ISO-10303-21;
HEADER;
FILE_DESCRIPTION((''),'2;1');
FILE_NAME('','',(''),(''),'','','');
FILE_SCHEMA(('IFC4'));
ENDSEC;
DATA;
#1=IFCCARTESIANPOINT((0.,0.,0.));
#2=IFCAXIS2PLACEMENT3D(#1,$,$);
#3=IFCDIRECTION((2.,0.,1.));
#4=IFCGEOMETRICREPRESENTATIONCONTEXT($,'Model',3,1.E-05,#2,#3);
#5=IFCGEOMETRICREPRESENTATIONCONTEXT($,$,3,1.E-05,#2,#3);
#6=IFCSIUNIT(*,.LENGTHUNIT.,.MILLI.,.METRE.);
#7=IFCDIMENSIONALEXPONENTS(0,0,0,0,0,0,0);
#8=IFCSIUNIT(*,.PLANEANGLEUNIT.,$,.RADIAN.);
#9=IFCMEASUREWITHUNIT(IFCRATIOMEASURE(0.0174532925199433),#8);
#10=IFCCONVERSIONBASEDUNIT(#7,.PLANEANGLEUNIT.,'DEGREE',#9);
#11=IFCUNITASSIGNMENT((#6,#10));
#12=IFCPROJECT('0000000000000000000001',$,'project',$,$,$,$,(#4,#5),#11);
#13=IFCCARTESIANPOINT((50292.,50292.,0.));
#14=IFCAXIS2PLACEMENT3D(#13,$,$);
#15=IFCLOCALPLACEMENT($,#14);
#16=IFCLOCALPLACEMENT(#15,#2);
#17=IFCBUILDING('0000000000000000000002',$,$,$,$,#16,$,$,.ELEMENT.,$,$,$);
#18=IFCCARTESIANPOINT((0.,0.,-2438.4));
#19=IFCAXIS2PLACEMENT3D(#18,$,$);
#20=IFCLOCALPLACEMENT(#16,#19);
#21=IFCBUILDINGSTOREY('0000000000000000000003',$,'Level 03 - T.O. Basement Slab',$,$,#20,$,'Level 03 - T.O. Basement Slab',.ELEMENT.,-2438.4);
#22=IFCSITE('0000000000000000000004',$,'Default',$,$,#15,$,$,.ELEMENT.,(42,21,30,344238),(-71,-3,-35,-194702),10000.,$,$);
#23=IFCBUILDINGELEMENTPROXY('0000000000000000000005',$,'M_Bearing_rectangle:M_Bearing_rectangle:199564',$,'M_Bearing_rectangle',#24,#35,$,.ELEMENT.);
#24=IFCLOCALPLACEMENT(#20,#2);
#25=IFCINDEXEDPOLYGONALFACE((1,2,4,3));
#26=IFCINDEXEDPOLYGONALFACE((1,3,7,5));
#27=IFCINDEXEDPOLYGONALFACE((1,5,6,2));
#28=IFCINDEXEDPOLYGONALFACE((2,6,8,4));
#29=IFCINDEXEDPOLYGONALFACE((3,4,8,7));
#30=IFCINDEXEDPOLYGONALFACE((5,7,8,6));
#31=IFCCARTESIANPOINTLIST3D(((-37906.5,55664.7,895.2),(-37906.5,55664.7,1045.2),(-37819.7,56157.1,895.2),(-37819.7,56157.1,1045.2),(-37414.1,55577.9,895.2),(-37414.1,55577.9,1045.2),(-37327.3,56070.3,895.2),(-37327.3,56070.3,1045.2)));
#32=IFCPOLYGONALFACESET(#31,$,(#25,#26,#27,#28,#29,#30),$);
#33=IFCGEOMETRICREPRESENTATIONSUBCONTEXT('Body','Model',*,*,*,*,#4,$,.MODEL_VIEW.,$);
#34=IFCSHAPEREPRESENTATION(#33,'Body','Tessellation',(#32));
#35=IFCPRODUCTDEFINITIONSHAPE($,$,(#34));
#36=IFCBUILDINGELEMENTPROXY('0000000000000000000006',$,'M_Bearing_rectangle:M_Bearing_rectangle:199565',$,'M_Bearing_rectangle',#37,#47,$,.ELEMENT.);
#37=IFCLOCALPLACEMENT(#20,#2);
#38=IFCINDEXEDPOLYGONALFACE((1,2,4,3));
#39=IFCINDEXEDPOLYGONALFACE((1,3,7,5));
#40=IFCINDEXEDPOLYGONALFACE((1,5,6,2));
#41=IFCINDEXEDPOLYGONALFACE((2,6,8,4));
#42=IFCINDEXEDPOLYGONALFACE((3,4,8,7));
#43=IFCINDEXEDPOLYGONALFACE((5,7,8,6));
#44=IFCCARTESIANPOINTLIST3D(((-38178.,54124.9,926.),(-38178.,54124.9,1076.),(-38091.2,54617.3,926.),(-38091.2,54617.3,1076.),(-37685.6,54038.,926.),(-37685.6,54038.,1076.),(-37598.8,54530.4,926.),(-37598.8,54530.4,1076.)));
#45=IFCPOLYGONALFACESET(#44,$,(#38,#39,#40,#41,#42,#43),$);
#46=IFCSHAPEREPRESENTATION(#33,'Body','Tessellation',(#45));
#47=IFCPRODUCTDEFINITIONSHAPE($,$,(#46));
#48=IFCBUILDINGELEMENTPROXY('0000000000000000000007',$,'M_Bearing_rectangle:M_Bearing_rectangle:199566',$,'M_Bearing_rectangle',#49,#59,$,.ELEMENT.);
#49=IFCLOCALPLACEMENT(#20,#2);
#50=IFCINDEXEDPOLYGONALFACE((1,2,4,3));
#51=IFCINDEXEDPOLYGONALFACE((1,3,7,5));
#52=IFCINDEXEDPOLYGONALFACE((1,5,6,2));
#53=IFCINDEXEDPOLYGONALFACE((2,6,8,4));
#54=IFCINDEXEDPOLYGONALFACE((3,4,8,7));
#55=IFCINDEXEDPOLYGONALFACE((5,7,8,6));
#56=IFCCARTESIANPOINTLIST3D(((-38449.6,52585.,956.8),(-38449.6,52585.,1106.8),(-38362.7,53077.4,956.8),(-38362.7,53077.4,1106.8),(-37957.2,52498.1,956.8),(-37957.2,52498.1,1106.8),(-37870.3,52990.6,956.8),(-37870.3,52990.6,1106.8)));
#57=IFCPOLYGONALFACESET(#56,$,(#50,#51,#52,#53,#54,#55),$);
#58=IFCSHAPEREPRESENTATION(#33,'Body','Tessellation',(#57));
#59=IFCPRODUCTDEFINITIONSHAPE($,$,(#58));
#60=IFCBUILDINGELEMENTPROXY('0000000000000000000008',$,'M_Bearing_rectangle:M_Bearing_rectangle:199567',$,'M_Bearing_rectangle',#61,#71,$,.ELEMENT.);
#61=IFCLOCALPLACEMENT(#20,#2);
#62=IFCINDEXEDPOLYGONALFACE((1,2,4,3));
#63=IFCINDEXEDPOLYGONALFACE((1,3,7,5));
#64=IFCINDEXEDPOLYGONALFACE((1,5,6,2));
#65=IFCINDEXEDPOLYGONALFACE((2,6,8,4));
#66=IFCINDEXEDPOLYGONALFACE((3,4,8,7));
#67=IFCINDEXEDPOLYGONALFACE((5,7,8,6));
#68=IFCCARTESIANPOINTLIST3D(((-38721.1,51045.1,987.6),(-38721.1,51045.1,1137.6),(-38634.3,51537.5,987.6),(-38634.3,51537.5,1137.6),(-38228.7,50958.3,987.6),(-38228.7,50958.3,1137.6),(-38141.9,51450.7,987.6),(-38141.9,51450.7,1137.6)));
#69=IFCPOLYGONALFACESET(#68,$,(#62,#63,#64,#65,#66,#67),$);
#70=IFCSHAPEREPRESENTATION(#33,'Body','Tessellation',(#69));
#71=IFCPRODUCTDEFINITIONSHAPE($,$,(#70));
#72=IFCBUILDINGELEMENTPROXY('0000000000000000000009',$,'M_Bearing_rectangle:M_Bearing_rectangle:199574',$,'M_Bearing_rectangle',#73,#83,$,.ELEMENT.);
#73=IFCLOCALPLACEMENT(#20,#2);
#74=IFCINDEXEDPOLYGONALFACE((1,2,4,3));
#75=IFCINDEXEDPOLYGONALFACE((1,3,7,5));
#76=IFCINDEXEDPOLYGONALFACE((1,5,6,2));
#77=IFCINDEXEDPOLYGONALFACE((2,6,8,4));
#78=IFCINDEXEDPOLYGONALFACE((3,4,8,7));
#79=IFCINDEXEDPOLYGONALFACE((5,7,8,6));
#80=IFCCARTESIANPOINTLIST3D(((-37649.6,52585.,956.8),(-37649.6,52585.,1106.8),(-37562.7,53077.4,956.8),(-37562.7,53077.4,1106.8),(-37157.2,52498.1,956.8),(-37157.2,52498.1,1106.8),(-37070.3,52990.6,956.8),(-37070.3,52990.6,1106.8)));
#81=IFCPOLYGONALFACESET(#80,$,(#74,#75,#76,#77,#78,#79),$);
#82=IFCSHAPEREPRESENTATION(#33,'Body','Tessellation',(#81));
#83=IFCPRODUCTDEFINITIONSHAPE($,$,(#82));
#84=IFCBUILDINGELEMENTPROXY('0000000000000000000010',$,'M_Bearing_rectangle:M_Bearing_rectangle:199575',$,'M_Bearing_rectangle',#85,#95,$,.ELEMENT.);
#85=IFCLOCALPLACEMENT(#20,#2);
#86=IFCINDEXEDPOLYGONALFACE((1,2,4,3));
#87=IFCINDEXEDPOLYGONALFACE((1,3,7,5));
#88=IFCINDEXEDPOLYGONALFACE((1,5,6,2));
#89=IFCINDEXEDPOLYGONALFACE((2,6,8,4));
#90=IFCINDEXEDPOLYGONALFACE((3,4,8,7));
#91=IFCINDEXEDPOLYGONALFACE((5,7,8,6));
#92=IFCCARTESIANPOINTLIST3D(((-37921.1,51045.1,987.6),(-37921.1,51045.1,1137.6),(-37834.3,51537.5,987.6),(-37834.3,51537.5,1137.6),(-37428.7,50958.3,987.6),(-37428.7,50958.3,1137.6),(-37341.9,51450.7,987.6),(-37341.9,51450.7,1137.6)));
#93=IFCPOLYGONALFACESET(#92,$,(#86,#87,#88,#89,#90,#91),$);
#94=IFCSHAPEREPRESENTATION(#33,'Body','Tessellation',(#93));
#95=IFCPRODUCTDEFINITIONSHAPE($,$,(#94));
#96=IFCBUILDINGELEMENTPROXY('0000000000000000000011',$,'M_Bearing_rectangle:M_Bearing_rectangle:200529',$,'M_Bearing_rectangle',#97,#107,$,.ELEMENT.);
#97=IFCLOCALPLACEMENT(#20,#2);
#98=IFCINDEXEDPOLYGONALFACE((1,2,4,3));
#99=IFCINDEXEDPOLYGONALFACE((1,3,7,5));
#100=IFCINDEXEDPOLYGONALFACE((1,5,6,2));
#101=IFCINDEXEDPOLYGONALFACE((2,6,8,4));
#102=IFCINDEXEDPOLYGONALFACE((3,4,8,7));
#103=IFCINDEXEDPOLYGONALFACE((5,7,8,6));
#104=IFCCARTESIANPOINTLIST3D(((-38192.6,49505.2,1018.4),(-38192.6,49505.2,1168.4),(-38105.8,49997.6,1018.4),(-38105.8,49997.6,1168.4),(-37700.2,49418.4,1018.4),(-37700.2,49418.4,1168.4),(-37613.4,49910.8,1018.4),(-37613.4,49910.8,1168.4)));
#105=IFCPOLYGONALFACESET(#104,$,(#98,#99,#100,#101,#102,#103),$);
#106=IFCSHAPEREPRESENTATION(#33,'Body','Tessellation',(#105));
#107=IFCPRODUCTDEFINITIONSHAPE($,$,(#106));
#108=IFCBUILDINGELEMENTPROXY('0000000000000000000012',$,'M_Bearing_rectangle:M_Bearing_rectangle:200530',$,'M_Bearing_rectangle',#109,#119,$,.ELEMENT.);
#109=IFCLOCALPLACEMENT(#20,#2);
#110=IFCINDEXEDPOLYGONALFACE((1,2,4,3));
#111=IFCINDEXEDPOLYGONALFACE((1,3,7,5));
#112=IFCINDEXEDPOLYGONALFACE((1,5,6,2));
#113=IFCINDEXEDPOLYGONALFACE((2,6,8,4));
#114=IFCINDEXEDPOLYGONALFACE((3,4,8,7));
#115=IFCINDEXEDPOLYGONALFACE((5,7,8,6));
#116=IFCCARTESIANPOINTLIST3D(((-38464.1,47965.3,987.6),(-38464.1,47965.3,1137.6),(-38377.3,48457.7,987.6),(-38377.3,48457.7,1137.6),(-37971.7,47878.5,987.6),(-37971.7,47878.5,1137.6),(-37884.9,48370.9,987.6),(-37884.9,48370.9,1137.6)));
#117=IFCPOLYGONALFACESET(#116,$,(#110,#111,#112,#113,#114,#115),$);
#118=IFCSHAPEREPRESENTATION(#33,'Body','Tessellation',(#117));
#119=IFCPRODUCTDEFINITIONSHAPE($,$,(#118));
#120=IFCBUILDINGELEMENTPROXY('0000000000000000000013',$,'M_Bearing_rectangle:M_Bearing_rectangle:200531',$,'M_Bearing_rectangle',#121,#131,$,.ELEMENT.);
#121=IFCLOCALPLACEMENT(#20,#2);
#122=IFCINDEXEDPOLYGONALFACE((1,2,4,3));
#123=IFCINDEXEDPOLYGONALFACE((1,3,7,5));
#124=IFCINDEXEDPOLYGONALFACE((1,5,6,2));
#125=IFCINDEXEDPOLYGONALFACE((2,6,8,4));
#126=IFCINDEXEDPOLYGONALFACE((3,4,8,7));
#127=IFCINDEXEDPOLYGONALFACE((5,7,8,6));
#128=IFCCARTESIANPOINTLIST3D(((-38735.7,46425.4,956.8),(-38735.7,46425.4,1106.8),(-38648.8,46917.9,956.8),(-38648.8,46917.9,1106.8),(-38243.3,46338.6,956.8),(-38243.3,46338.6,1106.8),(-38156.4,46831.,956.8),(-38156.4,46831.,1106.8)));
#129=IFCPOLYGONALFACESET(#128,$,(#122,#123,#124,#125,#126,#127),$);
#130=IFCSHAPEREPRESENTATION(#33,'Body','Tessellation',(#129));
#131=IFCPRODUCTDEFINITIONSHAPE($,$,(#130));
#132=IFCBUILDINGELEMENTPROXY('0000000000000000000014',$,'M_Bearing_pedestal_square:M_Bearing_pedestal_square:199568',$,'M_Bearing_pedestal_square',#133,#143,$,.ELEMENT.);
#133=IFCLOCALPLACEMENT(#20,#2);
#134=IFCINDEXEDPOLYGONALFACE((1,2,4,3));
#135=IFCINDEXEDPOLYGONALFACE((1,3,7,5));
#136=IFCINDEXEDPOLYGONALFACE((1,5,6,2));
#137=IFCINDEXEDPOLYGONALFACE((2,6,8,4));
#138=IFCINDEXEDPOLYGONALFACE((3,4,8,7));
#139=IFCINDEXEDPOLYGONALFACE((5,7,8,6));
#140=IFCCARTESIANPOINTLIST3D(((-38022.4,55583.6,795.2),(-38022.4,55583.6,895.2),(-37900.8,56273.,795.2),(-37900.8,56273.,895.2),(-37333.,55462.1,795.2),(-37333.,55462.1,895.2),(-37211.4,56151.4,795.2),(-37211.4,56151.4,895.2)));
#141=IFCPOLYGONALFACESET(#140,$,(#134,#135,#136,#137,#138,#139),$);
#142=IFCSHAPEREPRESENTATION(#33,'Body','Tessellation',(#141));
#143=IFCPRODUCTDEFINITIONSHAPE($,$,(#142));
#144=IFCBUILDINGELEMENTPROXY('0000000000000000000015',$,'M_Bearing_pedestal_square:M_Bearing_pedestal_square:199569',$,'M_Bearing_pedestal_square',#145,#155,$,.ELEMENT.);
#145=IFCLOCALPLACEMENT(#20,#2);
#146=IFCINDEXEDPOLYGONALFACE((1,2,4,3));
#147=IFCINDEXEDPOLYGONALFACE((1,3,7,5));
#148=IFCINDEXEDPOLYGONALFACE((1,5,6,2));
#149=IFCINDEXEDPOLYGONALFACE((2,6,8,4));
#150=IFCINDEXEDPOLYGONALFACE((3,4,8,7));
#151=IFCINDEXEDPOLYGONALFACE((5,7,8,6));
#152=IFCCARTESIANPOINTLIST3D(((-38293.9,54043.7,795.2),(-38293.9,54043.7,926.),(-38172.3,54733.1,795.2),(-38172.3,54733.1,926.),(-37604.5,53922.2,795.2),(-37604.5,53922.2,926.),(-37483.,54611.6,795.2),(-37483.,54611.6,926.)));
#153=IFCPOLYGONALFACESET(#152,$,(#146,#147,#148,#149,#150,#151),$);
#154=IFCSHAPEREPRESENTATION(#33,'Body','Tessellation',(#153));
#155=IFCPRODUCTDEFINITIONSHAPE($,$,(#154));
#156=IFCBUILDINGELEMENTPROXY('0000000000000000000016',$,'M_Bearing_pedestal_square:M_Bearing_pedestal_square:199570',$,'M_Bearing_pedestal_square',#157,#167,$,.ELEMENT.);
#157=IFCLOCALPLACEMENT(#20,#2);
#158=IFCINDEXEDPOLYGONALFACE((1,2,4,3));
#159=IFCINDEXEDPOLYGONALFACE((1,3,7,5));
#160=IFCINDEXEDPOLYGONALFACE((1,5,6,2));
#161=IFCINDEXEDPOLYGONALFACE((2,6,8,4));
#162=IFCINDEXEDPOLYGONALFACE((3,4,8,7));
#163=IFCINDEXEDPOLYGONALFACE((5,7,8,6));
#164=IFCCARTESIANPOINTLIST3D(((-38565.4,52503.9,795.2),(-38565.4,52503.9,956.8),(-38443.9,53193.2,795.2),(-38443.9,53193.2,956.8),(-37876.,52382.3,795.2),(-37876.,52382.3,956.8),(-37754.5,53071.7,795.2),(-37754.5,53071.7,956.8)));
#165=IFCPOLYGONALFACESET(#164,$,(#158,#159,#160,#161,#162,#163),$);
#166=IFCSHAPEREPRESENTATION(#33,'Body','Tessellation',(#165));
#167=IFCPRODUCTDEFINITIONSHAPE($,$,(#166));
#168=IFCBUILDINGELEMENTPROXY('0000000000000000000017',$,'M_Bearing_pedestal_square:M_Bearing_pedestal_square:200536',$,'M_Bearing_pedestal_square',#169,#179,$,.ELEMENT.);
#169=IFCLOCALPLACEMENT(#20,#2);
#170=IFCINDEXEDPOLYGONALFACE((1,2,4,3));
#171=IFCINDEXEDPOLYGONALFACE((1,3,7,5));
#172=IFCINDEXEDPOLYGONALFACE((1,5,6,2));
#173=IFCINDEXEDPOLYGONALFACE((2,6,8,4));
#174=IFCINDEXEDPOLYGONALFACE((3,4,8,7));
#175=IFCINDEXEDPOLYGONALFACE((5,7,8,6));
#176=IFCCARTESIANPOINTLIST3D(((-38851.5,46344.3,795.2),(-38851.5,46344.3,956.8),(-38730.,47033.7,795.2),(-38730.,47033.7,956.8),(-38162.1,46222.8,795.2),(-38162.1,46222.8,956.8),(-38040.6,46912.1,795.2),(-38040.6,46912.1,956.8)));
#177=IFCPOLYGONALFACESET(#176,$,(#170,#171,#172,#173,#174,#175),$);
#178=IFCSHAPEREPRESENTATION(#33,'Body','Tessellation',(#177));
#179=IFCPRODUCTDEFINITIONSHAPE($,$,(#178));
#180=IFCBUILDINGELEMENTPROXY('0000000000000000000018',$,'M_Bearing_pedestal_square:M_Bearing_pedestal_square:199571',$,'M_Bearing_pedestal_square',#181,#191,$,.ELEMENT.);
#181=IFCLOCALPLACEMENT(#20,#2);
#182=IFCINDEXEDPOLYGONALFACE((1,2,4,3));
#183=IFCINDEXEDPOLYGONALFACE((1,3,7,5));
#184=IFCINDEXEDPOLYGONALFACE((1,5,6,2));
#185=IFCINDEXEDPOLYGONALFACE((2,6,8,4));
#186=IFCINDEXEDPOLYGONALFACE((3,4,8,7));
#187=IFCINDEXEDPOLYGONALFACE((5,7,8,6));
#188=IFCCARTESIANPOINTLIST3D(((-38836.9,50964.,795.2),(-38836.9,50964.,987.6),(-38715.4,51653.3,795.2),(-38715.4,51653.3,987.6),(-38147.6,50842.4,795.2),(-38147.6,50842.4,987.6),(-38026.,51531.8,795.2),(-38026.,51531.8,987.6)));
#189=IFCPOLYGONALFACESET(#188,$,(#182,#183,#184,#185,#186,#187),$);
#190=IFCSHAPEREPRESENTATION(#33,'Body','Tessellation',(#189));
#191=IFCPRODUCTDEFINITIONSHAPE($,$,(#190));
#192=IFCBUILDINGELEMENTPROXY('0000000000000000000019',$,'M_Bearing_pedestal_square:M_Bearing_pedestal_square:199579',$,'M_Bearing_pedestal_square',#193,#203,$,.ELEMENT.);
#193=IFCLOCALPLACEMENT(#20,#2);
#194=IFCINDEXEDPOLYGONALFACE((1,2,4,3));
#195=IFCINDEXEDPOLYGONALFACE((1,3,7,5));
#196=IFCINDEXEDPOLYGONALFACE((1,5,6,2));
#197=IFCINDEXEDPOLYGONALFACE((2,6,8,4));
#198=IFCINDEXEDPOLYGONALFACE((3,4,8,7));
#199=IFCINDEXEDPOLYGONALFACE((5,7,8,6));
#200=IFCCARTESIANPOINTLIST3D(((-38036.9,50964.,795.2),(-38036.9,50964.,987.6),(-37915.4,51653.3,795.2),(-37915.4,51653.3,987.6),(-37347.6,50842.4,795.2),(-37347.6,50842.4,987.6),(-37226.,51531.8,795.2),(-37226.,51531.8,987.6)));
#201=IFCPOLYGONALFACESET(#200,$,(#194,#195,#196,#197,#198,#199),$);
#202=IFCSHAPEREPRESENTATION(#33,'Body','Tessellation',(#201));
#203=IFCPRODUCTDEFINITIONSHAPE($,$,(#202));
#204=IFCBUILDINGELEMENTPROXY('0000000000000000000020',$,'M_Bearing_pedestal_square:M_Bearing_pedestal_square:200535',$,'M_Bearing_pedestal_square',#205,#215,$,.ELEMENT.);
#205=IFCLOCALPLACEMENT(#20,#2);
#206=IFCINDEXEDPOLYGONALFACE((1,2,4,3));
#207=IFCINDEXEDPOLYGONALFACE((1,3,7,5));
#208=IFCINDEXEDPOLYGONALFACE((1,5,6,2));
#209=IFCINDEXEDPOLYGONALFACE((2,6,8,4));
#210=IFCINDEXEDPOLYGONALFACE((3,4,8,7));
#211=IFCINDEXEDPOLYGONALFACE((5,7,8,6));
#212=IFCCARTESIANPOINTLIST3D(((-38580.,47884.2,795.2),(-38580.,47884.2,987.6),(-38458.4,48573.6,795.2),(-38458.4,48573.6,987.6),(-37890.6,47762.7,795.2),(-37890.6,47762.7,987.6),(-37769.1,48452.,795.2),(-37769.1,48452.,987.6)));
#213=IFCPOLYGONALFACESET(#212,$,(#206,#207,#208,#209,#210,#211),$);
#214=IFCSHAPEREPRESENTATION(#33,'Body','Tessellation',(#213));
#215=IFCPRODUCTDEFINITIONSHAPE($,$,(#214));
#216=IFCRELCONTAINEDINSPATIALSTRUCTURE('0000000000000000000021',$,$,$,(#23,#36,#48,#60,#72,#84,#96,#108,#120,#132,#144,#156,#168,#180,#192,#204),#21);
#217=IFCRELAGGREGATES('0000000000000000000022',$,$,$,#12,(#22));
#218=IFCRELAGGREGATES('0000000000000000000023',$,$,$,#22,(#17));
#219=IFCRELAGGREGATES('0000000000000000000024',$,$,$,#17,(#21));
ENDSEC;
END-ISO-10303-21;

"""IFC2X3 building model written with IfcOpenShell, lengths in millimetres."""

from ifc_helpers import new_model, entity, si_unit, converted_unit, direction, frame, origin, origin_2d_with_axis, place, context, subcontext, project, spatial, rectangle, extrude, source, transform, mapped, element, save


model = new_model("IFC2X3")

# Units and contexts
model_context = context("Model", 3, precision=1e-05, world=origin(), true_north=direction((2.0, 0.0, 1.0)))
context_of_model = context(None, 3, precision=1e-05, world=origin(), true_north=direction((2.0, 0.0, 1.0)))
body_context = subcontext(model_context, "Body", "Model", "MODEL_VIEW")
ifc_project = project(units=[si_unit("LENGTHUNIT", "METRE", prefix="MILLI"), converted_unit("PLANEANGLEUNIT", "DEGREE", entity("IfcRatioMeasure", 0.0174532925199433), si_unit("PLANEANGLEUNIT", "RADIAN"), dimensions=[0, 0, 0, 0, 0, 0, 0])], contexts=[model_context, context_of_model])

# Site, building, storey
site_placement = place(None, frame((50292.0, 50292.0, 0.0)))
site = spatial("IfcSite", under=ifc_project, at=site_placement, Name="Default", CompositionType="ELEMENT", RefLatitude=(42, 21, 30, 344238), RefLongitude=(-71, -3, -35, -194702), RefElevation=10000.0)
building_placement = place(site_placement, origin())
building = spatial("IfcBuilding", under=site, at=building_placement, CompositionType="ELEMENT")
storey_placement = place(building_placement, frame((0.0, 0.0, -2438.4)))
storey = spatial("IfcBuildingStorey", under=building, at=storey_placement, Name="Level 03 - T.O. Basement Slab", LongName="Level 03 - T.O. Basement Slab", CompositionType="ELEMENT", Elevation=-2438.4)

# Building element proxies
shared_shape_1 = source(origin(), body_context, "Body", "SweptSolid", [
    extrude(rectangle(XDim=500.0, YDim=500.0, at=origin_2d_with_axis()), frame((0.0, 0.0, -150.0), z_axis=(0.0, 0.0, 1.0), x_axis=(-1.0, 0.0, 0.0)), (0.0, 0.0, 1.0), 150.0),
])
for number, where, z_axis, x_axis, name in (
    (1, (-37616.9, 55867.5, 1045.2), (0.0, 0.0, 1.0), (0.173648, 0.984808, 0.0), "M_Bearing_rectangle:M_Bearing_rectangle:199564"),
    (2, (-37888.4, 54327.6, 1076.0), (0.0, 0.0, 1.0), (0.173648, 0.984808, 0.0), "M_Bearing_rectangle:M_Bearing_rectangle:199565"),
    (3, (-38160.0, 52787.8, 1106.8), (0.0, 0.0, 1.0), (0.173648, 0.984808, 0.0), "M_Bearing_rectangle:M_Bearing_rectangle:199566"),
    (4, (-38431.5, 51247.9, 1137.6), (0.0, 0.0, 1.0), (0.173648, 0.984808, 0.0), "M_Bearing_rectangle:M_Bearing_rectangle:199567"),
    (5, (-37360.0, 52787.8, 1106.8), (0.0, 0.0, 1.0), (0.173648, 0.984808, 0.0), "M_Bearing_rectangle:M_Bearing_rectangle:199574"),
    (6, (-37631.5, 51247.9, 1137.6), (0.0, 0.0, 1.0), (0.173648, 0.984808, 0.0), "M_Bearing_rectangle:M_Bearing_rectangle:199575"),
    (7, (-37903.0, 49708.0, 1168.4), (0.0, 0.0, 1.0), (0.173648, 0.984808, 0.0), "M_Bearing_rectangle:M_Bearing_rectangle:200529"),
    (8, (-38174.5, 48168.1, 1137.6), (0.0, 0.0, 1.0), (0.173648, 0.984808, 0.0), "M_Bearing_rectangle:M_Bearing_rectangle:200530"),
    (9, (-38446.0, 46628.2, 1106.8), (0.0, 0.0, 1.0), (0.173648, 0.984808, 0.0), "M_Bearing_rectangle:M_Bearing_rectangle:200531"),
):
    element("IfcBuildingElementProxy", number, at=place(storey_placement, frame(where, z_axis=z_axis, x_axis=x_axis)), inside=storey, Name=name, ObjectType="M_Bearing_rectangle", CompositionType="ELEMENT", context=body_context, shape_type="MappedRepresentation", body=[
        mapped(shared_shape_1, transform((0.0, 0.0, 0.0), scale=1.0)),
    ])
shared_shape_2 = source(origin(), body_context, "Body", "SweptSolid", [
    extrude(rectangle(XDim=700.0, YDim=700.0, at=origin_2d_with_axis()), frame((0.0, 0.0, -100.0)), (0.0, 0.0, 1.0), 100.0),
])
proxy_1_placement = place(storey_placement, frame((-37616.9, 55867.5, 895.2), z_axis=(0.0, 0.0, 1.0), x_axis=(0.173648, 0.984808, 0.0)))
element("IfcBuildingElementProxy", 10, at=proxy_1_placement, inside=storey, Name="M_Bearing_pedestal_square:M_Bearing_pedestal_square:199568", ObjectType="M_Bearing_pedestal_square", CompositionType="ELEMENT", context=body_context, shape_type="MappedRepresentation", body=[
    mapped(shared_shape_2, transform((0.0, 0.0, 0.0), scale=1.0)),
])
shared_shape_3 = source(origin(), body_context, "Body", "SweptSolid", [
    extrude(rectangle(XDim=700.0, YDim=700.0, at=origin_2d_with_axis()), frame((0.0, 0.0, -130.8)), (0.0, 0.0, 1.0), 130.8),
])
proxy_2_placement = place(storey_placement, frame((-37888.4, 54327.6, 926.0), z_axis=(0.0, 0.0, 1.0), x_axis=(0.173648, 0.984808, 0.0)))
element("IfcBuildingElementProxy", 11, at=proxy_2_placement, inside=storey, Name="M_Bearing_pedestal_square:M_Bearing_pedestal_square:199569", ObjectType="M_Bearing_pedestal_square", CompositionType="ELEMENT", context=body_context, shape_type="MappedRepresentation", body=[
    mapped(shared_shape_3, transform((0.0, 0.0, 0.0), scale=1.0)),
])
shared_shape_4 = source(origin(), body_context, "Body", "SweptSolid", [
    extrude(rectangle(XDim=700.0, YDim=700.0, at=origin_2d_with_axis()), frame((0.0, 0.0, -161.6)), (0.0, 0.0, 1.0), 161.6),
])
for number, where, z_axis, x_axis, name in (
    (12, (-38160.0, 52787.8, 956.8), (0.0, 0.0, 1.0), (0.173648, 0.984808, 0.0), "M_Bearing_pedestal_square:M_Bearing_pedestal_square:199570"),
    (13, (-38446.0, 46628.2, 956.8), (0.0, 0.0, 1.0), (0.173648, 0.984808, 0.0), "M_Bearing_pedestal_square:M_Bearing_pedestal_square:200536"),
):
    element("IfcBuildingElementProxy", number, at=place(storey_placement, frame(where, z_axis=z_axis, x_axis=x_axis)), inside=storey, Name=name, ObjectType="M_Bearing_pedestal_square", CompositionType="ELEMENT", context=body_context, shape_type="MappedRepresentation", body=[
        mapped(shared_shape_4, transform((0.0, 0.0, 0.0), scale=1.0)),
    ])
shared_shape_5 = source(origin(), body_context, "Body", "SweptSolid", [
    extrude(rectangle(XDim=700.0, YDim=700.0, at=origin_2d_with_axis()), frame((0.0, 0.0, -192.4)), (0.0, 0.0, 1.0), 192.4),
])
for number, where, z_axis, x_axis, name in (
    (14, (-38431.5, 51247.9, 987.6), (0.0, 0.0, 1.0), (0.173648, 0.984808, 0.0), "M_Bearing_pedestal_square:M_Bearing_pedestal_square:199571"),
    (15, (-37631.5, 51247.9, 987.6), (0.0, 0.0, 1.0), (0.173648, 0.984808, 0.0), "M_Bearing_pedestal_square:M_Bearing_pedestal_square:199579"),
    (16, (-38174.5, 48168.1, 987.6), (0.0, 0.0, 1.0), (0.173648, 0.984808, 0.0), "M_Bearing_pedestal_square:M_Bearing_pedestal_square:200535"),
):
    element("IfcBuildingElementProxy", number, at=place(storey_placement, frame(where, z_axis=z_axis, x_axis=x_axis)), inside=storey, Name=name, ObjectType="M_Bearing_pedestal_square", CompositionType="ELEMENT", context=body_context, shape_type="MappedRepresentation", body=[
        mapped(shared_shape_5, transform((0.0, 0.0, 0.0), scale=1.0)),
    ])

save(model, "model.ifc")
